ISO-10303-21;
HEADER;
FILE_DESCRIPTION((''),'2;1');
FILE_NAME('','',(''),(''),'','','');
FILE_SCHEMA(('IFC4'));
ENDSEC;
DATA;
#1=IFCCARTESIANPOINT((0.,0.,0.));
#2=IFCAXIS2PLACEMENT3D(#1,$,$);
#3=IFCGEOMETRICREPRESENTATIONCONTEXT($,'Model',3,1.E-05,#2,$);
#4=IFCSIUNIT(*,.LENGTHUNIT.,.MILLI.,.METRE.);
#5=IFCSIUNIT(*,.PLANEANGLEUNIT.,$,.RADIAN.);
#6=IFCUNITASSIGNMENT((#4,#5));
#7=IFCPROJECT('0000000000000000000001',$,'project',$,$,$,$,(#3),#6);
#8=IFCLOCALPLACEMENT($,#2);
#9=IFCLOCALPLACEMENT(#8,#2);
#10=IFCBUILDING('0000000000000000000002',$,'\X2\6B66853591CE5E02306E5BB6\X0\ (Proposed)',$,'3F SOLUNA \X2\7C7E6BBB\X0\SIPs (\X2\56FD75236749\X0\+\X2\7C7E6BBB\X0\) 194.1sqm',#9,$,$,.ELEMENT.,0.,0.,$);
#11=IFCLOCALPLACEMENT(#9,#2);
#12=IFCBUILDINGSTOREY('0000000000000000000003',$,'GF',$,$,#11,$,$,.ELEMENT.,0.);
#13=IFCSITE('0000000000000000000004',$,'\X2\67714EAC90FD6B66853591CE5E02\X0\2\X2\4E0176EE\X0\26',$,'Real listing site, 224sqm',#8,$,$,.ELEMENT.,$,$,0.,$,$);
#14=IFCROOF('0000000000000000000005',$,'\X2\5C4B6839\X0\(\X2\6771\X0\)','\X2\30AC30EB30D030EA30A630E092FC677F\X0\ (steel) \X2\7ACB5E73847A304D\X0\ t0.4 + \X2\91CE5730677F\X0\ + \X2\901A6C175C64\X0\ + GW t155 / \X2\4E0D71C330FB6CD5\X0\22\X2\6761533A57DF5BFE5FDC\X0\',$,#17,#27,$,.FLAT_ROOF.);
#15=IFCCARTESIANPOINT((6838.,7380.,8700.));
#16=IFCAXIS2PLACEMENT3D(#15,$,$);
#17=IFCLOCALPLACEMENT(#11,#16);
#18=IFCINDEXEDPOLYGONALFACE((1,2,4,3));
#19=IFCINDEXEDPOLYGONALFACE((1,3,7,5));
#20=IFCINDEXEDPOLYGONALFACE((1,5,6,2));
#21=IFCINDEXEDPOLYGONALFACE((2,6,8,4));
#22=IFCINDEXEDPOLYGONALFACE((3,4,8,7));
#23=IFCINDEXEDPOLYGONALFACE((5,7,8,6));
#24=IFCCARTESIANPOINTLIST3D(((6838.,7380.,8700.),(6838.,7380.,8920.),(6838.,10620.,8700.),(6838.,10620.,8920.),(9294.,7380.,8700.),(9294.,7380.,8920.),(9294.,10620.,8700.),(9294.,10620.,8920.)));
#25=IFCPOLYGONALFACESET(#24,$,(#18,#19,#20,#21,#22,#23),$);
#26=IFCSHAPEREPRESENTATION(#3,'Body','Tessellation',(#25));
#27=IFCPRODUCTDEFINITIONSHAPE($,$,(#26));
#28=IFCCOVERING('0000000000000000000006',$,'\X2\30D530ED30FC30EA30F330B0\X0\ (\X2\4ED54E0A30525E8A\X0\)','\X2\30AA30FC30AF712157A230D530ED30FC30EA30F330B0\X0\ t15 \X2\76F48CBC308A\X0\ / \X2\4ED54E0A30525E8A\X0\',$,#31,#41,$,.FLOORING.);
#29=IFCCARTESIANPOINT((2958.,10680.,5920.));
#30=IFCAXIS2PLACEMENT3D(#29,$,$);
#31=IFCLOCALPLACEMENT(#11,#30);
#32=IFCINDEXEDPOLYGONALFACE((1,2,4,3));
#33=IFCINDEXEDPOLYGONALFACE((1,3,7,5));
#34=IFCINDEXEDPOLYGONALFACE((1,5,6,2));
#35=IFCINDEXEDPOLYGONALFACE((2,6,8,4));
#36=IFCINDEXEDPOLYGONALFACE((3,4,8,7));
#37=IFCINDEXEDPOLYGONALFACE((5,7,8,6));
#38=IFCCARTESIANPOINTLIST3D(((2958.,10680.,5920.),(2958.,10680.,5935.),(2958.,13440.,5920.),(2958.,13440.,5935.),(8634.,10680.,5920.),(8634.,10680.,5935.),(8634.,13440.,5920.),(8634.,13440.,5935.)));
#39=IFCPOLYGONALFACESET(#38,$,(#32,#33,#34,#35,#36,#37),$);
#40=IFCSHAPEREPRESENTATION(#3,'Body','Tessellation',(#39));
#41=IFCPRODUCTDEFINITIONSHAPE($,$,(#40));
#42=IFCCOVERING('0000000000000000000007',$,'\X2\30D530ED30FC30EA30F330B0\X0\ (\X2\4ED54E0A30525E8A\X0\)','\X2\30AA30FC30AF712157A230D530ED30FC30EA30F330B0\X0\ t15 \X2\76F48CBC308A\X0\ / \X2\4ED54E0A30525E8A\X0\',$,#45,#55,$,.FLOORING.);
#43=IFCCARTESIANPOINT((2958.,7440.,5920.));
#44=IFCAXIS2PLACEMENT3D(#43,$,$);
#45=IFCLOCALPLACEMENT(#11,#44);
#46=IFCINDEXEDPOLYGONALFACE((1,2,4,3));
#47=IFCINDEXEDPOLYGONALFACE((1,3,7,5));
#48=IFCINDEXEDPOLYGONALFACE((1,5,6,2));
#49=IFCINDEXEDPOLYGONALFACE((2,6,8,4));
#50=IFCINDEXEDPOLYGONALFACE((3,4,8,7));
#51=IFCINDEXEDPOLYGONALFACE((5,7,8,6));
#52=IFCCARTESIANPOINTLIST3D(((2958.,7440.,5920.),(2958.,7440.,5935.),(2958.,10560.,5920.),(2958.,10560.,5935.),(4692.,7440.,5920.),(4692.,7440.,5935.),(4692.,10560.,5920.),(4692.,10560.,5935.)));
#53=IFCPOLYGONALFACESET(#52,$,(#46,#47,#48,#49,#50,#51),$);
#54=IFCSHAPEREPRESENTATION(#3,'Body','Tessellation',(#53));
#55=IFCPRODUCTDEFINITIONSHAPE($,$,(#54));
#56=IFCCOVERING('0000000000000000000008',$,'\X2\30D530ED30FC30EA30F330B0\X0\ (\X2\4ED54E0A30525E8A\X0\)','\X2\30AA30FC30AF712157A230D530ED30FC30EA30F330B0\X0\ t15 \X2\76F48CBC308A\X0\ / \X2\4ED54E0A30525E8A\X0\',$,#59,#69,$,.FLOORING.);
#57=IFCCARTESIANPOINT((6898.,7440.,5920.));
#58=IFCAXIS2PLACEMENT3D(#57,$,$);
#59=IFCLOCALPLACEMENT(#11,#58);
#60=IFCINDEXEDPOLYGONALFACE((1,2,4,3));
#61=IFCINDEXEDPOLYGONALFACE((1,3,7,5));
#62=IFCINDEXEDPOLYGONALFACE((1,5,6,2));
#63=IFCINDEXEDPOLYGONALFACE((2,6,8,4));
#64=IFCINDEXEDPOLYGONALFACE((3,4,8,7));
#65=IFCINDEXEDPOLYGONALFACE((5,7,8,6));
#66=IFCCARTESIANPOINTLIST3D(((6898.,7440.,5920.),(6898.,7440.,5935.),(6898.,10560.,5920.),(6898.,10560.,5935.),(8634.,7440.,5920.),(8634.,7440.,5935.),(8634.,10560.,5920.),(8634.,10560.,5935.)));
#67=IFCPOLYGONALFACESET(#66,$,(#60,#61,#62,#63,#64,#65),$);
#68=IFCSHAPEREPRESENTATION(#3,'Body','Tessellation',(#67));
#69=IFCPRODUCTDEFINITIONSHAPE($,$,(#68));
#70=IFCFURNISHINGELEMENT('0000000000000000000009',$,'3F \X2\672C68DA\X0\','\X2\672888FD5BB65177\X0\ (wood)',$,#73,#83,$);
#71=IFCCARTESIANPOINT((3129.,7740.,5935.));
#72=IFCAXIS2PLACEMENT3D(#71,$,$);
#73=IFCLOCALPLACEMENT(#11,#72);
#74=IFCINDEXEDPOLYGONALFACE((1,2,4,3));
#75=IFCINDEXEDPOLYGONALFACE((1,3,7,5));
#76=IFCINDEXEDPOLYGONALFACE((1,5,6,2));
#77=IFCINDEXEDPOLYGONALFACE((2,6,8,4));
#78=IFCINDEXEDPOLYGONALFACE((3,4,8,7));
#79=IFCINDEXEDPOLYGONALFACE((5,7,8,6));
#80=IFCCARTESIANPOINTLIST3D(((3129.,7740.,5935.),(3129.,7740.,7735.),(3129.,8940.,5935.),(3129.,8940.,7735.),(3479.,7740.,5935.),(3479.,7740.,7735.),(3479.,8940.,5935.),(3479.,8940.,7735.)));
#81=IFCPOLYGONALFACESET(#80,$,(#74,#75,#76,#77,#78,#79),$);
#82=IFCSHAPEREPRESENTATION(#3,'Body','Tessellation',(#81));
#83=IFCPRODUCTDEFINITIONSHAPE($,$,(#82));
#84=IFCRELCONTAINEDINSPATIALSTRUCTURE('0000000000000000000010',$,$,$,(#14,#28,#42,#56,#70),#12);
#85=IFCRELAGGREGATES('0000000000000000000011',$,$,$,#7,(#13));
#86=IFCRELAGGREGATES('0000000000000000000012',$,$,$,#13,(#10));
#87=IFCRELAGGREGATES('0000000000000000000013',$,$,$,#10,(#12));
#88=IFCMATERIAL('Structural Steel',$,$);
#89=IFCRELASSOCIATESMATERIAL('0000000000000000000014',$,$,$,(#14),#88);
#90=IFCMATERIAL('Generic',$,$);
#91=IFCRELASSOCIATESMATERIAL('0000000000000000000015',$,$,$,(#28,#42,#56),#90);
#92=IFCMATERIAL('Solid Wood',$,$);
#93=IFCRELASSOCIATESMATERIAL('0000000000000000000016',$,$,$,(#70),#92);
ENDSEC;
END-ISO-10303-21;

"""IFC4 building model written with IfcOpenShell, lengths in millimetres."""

from ifc_helpers import new_model, si_unit, frame, frame_2d, origin, place, context, project, spatial, rectangle, extrude, material, element, save


model = new_model("IFC4")

# Units and contexts
model_context = context("Model", 3, precision=1e-05, world=origin())
ifc_project = project(units=[si_unit("LENGTHUNIT", "METRE", prefix="MILLI"), si_unit("PLANEANGLEUNIT", "RADIAN")], contexts=[model_context])

# Site, building, storey
site_placement = place(None, origin())
site = spatial("IfcSite", under=ifc_project, at=site_placement, Name="東京都武蔵野市2丁目26", ObjectType="Real listing site, 224sqm", CompositionType="ELEMENT", RefElevation=0.0)
building_placement = place(site_placement, origin())
building = spatial("IfcBuilding", under=site, at=building_placement, Name="武蔵野市の家 (Proposed)", ObjectType="3F SOLUNA 籾殻SIPs (国産杉+籾殻) 194.1sqm", CompositionType="ELEMENT", ElevationOfRefHeight=0.0, ElevationOfTerrain=0.0)
storey_placement = place(building_placement, origin())
storey = spatial("IfcBuildingStorey", under=building, at=storey_placement, Name="GF", CompositionType="ELEMENT", Elevation=0.0)

# Shared definitions
ifc_material_1 = material(Name="Solid Wood")

# Shared definitions
ifc_material_2 = material(Name="Generic")

# Roof
ifc_material_3 = material(Name="Structural Steel")
roof_1_placement = place(storey_placement, frame((6838.0, 7380.0, 8700.0)))
element("IfcRoof", 1, at=roof_1_placement, inside=storey, material=ifc_material_3, Name="屋根(東)", Description="ガルバリウム鋼板 (steel) 立平葺き t0.4 + 野地板 + 通気層 + GW t155 / 不燃・法22条区域対応", PredefinedType="FLAT_ROOF", context=model_context, shape_type="SweptSolid", body=[
    extrude(rectangle(XDim=2456.0, YDim=3240.0, at=frame_2d((1228.0, 1620.0))), frame((6838.0, 7380.0, 8700.0)), (0.0, 0.0, 1.0), 220.0),
])

# Coverings
covering_1_placement = place(storey_placement, frame((2958.0, 10680.0, 5920.0)))
element("IfcCovering", 2, at=covering_1_placement, inside=storey, material=ifc_material_2, Name="フローリング (仕上げ床)", Description="オーク無垢フローリング t15 直貼り / 仕上げ床", PredefinedType="FLOORING", context=model_context, shape_type="SweptSolid", body=[
    extrude(rectangle(XDim=5676.0, YDim=2760.0, at=frame_2d((2838.0, 1380.0))), frame((2958.0, 10680.0, 5920.0)), (0.0, 0.0, 1.0), 15.0),
])
covering_2_placement = place(storey_placement, frame((2958.0, 7440.0, 5920.0)))
element("IfcCovering", 3, at=covering_2_placement, inside=storey, material=ifc_material_2, Name="フローリング (仕上げ床)", Description="オーク無垢フローリング t15 直貼り / 仕上げ床", PredefinedType="FLOORING", context=model_context, shape_type="SweptSolid", body=[
    extrude(rectangle(XDim=1734.0, YDim=3120.0, at=frame_2d((867.0, 1560.0))), frame((2958.0, 7440.0, 5920.0)), (0.0, 0.0, 1.0), 15.0),
])
covering_3_placement = place(storey_placement, frame((6898.0, 7440.0, 5920.0)))
element("IfcCovering", 4, at=covering_3_placement, inside=storey, material=ifc_material_2, Name="フローリング (仕上げ床)", Description="オーク無垢フローリング t15 直貼り / 仕上げ床", PredefinedType="FLOORING", context=model_context, shape_type="SweptSolid", body=[
    extrude(rectangle(XDim=1736.0, YDim=3120.0, at=frame_2d((868.0, 1560.0))), frame((6898.0, 7440.0, 5920.0)), (0.0, 0.0, 1.0), 15.0),
])

# Furnishing element
furnishing_placement = place(storey_placement, frame((3129.0, 7740.0, 5935.0)))
element("IfcFurnishingElement", 5, at=furnishing_placement, inside=storey, material=ifc_material_1, Name="3F 本棚", Description="木製家具 (wood)", context=model_context, shape_type="SweptSolid", body=[
    extrude(rectangle(XDim=350.0, YDim=1200.0, at=frame_2d((175.0, 600.0))), frame((3129.0, 7740.0, 5935.0)), (0.0, 0.0, 1.0), 1800.0),
])

save(model, "model.ifc")
